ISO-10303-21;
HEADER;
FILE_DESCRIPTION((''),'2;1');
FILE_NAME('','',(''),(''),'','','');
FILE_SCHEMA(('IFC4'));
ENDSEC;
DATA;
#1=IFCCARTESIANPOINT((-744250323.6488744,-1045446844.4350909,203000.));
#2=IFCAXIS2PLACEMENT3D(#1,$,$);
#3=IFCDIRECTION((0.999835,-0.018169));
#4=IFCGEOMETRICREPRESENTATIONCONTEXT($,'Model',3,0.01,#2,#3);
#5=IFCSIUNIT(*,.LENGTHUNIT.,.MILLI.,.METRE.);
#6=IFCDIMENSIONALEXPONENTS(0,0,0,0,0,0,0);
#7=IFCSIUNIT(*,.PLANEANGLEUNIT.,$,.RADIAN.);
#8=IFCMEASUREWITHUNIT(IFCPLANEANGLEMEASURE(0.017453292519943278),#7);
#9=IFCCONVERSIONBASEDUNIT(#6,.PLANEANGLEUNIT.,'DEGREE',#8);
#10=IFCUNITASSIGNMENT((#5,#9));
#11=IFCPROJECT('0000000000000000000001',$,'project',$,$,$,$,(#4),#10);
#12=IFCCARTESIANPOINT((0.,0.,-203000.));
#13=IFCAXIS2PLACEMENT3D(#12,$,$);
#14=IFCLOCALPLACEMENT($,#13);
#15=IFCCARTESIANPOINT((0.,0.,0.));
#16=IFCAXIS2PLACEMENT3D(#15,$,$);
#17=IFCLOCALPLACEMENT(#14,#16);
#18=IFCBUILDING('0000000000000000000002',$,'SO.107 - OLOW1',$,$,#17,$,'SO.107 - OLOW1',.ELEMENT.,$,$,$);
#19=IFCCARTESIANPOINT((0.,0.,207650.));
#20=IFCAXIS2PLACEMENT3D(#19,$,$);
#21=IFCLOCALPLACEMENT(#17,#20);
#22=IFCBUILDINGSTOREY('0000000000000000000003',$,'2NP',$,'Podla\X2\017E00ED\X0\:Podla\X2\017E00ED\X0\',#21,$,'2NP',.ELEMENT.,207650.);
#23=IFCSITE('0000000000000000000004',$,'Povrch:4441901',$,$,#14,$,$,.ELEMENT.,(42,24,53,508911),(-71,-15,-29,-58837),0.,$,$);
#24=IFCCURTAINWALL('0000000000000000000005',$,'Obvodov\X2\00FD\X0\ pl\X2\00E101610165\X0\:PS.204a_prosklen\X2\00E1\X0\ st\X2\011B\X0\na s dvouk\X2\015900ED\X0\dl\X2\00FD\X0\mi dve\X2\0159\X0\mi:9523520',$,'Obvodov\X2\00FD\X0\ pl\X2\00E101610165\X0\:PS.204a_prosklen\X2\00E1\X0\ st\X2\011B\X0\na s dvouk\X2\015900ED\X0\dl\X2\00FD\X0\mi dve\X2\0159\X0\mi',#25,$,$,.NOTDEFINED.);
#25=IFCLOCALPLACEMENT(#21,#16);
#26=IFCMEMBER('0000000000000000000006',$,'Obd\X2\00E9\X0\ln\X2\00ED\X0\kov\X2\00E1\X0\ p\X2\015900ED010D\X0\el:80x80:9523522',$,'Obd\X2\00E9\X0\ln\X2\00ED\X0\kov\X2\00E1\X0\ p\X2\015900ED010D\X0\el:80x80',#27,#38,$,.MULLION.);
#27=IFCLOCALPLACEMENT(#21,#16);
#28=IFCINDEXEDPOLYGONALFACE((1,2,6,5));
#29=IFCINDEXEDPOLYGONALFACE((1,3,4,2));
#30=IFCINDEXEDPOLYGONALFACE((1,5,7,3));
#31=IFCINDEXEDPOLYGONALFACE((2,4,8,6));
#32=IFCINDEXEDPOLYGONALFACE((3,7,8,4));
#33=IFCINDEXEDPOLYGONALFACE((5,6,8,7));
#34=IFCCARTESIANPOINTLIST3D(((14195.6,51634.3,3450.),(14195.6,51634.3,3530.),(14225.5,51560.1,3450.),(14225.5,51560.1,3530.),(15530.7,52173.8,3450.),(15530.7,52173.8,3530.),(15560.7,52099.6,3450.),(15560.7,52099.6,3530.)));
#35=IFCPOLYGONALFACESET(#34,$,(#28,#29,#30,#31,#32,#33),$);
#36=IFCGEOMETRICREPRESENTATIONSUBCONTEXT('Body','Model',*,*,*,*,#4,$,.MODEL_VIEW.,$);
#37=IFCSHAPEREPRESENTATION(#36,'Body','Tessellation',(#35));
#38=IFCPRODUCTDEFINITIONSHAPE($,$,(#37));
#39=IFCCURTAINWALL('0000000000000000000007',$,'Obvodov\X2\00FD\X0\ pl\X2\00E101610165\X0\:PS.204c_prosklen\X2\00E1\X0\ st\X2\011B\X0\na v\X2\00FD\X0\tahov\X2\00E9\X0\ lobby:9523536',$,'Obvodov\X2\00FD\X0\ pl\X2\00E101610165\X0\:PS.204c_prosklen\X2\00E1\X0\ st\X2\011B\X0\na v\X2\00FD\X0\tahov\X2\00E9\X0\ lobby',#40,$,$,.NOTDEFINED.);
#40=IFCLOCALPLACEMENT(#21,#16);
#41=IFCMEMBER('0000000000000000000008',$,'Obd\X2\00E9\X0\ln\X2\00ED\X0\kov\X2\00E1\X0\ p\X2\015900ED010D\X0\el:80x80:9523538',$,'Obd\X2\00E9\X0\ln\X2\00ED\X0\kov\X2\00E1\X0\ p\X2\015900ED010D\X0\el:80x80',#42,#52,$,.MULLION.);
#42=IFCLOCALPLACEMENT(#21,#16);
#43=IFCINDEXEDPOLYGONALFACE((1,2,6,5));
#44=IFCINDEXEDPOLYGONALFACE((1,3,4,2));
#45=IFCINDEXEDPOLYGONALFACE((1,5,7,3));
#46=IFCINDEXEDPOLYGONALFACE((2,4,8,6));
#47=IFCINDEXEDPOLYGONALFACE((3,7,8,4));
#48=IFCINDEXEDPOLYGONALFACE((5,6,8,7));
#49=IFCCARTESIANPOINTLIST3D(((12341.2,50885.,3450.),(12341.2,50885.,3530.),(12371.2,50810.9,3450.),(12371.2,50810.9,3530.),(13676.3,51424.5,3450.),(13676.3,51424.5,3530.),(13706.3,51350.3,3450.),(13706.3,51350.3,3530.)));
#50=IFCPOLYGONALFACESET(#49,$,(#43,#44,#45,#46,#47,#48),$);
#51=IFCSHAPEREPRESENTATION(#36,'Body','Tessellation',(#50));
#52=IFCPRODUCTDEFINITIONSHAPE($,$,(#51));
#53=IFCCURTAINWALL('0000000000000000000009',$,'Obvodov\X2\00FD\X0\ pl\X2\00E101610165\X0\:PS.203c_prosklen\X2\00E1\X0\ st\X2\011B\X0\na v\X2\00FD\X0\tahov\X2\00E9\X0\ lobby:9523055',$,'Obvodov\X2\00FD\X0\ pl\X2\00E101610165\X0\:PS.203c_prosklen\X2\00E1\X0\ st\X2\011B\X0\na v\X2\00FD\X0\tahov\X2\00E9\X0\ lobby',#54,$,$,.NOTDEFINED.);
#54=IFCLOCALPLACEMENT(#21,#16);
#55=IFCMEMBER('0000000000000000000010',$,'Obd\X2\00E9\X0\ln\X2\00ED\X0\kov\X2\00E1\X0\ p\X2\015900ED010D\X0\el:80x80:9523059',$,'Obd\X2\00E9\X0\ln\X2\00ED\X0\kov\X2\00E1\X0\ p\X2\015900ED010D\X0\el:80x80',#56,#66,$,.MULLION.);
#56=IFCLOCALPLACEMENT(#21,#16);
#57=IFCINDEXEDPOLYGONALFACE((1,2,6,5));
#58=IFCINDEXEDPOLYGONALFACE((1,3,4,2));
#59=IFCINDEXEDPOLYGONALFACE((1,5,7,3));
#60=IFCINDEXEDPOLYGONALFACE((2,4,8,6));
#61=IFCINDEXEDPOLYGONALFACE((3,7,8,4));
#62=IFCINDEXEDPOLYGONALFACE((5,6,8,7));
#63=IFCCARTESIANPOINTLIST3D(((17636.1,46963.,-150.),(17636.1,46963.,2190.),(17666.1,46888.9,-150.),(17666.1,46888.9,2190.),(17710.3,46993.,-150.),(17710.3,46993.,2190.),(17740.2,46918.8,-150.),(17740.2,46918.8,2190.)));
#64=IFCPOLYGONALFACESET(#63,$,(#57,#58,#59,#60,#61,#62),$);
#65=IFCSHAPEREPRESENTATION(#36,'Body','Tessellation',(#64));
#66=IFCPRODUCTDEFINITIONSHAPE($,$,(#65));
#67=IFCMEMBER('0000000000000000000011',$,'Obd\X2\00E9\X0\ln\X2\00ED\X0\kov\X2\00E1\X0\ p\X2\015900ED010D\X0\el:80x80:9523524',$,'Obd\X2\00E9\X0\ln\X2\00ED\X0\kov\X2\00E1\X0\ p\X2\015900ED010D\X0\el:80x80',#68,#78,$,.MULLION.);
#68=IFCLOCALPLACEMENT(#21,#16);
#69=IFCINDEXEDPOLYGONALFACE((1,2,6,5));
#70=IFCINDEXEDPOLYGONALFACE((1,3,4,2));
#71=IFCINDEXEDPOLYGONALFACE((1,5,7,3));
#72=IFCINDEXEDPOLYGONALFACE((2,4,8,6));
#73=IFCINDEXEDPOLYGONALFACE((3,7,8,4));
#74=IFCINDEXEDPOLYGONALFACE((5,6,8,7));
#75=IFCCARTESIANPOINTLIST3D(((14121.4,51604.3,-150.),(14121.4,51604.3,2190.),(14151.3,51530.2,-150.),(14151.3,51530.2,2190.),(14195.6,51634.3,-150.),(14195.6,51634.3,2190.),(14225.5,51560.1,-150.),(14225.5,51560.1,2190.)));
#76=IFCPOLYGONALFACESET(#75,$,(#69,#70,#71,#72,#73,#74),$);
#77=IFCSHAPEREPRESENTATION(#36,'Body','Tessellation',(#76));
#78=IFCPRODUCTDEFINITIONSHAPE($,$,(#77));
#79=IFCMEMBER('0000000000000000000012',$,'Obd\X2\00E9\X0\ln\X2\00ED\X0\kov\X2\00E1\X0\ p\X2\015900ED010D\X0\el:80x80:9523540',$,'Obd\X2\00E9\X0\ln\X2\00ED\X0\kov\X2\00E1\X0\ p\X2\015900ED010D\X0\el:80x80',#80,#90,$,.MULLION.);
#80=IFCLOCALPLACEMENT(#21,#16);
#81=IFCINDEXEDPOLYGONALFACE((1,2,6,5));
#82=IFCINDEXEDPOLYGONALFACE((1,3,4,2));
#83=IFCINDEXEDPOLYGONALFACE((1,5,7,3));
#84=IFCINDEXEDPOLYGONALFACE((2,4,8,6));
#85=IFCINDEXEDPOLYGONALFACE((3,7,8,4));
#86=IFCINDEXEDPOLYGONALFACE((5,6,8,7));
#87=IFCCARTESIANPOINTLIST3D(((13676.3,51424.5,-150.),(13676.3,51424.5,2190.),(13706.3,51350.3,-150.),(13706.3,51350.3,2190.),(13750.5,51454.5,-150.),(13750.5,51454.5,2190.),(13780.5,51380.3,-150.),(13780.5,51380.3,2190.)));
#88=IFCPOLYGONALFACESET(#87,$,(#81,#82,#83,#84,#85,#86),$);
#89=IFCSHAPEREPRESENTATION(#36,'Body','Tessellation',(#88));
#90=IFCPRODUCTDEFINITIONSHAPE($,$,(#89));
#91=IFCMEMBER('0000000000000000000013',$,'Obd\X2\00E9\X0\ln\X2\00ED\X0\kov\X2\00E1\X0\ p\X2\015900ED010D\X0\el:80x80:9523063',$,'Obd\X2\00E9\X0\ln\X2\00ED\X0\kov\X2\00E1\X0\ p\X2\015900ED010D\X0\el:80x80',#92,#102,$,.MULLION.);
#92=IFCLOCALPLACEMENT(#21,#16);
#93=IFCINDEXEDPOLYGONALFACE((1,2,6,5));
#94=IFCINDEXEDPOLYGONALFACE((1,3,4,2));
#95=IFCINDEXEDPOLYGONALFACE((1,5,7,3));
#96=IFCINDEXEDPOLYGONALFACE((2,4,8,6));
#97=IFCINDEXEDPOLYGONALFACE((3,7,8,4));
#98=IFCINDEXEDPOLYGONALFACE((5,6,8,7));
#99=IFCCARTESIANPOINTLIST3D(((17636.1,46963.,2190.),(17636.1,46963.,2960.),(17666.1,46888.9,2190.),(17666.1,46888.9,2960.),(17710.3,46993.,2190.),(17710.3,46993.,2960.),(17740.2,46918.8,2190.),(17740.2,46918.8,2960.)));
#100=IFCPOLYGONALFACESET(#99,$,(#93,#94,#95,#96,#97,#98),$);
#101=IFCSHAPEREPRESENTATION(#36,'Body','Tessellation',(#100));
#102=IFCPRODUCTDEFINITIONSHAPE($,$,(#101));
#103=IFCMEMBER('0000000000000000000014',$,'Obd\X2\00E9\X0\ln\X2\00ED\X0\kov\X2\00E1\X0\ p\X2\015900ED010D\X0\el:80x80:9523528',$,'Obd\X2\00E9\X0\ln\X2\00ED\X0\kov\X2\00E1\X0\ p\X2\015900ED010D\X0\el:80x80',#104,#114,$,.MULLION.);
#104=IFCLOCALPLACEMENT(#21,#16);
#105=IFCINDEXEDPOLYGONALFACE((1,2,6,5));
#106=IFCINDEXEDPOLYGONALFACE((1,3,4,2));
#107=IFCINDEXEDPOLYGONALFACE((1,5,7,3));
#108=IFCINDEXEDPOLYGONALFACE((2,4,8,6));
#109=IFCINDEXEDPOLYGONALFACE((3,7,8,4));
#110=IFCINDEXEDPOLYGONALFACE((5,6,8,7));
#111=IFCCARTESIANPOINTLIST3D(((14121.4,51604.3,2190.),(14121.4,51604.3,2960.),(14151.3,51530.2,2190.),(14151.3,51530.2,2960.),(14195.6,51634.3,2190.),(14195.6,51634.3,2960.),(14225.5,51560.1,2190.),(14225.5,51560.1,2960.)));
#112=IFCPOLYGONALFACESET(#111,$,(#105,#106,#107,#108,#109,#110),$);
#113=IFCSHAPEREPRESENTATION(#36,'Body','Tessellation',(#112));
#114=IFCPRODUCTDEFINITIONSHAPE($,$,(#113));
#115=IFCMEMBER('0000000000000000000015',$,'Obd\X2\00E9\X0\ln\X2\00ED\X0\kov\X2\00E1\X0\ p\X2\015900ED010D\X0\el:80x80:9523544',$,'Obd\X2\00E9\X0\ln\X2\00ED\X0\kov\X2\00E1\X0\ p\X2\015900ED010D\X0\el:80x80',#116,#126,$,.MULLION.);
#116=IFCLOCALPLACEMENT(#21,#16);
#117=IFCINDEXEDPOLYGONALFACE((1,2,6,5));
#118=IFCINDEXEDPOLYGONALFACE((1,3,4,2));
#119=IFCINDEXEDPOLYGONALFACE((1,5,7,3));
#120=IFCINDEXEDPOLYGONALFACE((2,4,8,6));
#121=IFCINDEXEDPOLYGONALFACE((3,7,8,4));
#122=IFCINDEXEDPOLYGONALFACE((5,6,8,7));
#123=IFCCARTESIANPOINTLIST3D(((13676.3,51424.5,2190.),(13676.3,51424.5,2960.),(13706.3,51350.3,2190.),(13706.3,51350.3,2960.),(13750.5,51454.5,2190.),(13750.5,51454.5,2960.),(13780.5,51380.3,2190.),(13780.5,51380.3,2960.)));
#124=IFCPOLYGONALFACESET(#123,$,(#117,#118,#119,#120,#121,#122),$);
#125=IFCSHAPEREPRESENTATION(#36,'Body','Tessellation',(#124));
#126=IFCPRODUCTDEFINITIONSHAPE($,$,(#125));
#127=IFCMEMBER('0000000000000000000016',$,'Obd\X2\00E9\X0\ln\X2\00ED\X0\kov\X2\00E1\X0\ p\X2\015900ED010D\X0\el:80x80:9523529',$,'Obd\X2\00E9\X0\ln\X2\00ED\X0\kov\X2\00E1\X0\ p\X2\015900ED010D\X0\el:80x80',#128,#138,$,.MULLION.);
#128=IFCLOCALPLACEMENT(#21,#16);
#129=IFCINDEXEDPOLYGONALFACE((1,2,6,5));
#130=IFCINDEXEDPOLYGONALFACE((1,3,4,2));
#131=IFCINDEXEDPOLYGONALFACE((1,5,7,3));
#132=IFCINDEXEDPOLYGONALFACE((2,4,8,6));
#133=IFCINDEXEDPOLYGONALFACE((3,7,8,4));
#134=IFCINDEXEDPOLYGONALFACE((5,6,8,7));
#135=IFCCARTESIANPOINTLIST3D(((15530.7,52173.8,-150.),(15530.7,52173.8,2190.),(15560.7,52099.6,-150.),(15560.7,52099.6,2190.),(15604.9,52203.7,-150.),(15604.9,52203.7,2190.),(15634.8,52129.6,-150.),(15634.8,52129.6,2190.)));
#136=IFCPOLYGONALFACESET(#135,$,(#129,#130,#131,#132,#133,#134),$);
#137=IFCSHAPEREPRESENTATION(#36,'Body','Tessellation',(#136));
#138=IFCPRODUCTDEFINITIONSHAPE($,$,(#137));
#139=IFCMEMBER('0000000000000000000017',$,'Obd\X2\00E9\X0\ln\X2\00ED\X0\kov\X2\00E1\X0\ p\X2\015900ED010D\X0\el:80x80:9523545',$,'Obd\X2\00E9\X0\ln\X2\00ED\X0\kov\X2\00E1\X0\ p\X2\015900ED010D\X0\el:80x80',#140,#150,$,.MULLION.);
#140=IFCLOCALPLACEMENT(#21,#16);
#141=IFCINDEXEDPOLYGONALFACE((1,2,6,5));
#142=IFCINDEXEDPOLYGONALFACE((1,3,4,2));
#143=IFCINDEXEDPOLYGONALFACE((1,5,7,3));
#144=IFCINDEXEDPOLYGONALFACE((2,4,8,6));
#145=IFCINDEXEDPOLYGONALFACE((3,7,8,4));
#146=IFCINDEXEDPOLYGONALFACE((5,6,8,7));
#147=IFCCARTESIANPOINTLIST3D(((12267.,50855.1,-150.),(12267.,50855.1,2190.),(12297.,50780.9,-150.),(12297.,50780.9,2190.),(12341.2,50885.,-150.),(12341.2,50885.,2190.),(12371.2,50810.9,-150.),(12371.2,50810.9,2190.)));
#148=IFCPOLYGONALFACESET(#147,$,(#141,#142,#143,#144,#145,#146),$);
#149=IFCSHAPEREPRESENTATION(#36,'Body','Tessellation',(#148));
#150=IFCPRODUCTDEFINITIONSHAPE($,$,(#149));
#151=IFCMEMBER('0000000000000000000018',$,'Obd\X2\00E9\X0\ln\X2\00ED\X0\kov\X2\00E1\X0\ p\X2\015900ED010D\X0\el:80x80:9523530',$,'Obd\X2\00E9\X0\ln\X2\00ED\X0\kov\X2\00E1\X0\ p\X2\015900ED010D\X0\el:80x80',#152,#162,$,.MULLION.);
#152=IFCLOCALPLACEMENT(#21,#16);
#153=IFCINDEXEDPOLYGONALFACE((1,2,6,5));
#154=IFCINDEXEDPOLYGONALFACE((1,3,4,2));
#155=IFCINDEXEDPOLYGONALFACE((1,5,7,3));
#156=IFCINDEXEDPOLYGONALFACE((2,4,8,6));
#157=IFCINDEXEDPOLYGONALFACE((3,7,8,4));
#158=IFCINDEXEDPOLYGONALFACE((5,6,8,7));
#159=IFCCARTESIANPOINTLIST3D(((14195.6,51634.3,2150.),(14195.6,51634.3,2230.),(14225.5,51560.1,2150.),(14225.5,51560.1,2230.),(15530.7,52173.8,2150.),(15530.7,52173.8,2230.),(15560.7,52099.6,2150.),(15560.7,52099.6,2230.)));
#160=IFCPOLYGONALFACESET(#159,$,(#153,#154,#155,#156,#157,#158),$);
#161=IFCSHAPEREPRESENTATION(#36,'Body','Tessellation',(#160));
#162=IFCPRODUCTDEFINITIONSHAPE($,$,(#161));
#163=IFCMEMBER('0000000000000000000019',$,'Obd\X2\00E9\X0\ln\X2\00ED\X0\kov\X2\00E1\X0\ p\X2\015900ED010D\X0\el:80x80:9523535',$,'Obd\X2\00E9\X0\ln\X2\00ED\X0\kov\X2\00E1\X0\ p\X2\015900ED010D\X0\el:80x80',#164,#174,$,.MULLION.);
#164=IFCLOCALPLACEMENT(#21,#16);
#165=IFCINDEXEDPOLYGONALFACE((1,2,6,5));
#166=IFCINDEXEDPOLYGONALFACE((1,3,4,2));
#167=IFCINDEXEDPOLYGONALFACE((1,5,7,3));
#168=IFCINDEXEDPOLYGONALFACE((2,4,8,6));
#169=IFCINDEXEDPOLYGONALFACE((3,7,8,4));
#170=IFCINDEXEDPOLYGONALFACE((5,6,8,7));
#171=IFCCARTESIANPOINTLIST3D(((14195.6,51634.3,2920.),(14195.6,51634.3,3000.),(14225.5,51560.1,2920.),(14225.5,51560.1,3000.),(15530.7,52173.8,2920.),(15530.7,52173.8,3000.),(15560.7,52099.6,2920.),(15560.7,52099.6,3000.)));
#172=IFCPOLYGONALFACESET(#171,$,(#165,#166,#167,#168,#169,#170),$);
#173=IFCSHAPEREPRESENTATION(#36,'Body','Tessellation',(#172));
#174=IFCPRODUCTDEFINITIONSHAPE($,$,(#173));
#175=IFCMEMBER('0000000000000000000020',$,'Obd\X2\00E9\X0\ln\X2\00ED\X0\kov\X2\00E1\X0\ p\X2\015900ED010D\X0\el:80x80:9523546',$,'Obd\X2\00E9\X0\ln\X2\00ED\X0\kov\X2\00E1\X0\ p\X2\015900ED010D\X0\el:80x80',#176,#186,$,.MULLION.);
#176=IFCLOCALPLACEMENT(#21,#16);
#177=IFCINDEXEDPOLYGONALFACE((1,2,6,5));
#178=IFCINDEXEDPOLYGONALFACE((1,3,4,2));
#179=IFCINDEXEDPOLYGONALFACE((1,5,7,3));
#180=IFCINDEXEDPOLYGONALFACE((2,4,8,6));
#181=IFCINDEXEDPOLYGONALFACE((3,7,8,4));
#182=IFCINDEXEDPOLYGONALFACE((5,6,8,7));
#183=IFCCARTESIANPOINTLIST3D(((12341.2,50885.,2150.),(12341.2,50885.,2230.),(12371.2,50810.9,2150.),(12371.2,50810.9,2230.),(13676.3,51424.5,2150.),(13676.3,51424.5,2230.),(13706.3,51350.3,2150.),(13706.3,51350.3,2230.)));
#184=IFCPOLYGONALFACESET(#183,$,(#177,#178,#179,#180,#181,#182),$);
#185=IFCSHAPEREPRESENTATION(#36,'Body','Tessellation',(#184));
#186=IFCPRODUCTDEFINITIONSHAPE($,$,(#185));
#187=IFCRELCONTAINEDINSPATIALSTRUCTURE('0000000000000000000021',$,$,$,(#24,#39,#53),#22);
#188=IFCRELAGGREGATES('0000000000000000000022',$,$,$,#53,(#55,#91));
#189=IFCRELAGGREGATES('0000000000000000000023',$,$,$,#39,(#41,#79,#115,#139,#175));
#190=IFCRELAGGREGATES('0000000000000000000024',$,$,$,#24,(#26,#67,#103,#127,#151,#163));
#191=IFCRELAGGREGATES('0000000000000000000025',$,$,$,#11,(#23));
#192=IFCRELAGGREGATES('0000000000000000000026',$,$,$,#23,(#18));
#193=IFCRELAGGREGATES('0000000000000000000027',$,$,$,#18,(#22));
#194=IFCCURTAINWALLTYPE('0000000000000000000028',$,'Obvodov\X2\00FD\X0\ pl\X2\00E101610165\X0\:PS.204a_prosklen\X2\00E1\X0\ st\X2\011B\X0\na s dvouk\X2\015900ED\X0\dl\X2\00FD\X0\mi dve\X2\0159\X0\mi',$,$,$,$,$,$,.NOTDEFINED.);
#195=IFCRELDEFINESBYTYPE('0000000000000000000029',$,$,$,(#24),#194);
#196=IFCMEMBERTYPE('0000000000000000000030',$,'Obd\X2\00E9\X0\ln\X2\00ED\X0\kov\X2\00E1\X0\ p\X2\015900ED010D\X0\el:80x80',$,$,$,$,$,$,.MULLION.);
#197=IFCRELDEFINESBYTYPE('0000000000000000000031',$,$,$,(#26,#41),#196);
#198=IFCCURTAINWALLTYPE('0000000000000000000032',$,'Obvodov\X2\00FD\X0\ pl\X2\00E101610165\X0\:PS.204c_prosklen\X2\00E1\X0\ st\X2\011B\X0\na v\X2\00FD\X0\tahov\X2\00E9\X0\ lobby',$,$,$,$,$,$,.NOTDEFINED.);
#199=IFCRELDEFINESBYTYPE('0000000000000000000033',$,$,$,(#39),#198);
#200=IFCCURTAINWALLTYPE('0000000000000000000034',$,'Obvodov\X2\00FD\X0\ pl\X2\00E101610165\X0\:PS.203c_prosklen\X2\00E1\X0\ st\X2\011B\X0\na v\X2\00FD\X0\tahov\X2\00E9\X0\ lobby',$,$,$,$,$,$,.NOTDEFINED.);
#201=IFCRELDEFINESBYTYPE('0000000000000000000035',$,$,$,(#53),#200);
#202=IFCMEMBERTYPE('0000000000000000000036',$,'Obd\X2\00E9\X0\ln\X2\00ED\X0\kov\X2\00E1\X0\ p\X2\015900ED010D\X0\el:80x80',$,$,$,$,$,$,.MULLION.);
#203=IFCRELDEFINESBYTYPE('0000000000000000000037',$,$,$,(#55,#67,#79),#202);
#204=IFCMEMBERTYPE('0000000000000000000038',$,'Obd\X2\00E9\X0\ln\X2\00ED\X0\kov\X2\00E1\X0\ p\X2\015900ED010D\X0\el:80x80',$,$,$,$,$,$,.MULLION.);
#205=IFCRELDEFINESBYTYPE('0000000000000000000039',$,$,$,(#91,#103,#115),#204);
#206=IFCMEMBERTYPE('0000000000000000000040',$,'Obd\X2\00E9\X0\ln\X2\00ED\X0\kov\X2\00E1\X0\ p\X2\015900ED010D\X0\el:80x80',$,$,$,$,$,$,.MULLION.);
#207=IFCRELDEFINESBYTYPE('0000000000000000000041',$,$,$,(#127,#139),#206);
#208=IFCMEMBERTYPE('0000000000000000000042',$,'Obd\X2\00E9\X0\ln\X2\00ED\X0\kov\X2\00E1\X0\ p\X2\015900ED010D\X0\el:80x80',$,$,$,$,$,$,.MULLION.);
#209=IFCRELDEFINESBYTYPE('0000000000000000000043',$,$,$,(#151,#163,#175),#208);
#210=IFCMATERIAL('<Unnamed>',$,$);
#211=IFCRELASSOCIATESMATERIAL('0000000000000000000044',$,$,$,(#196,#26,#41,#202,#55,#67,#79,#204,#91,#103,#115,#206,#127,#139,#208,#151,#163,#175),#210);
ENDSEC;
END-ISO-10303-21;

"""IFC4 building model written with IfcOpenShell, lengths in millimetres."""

from ifc_helpers import new_model, entity, si_unit, converted_unit, direction, frame, origin, place, context, subcontext, project, spatial, indexed_curve, outline, extrude, source, transform, mapped, material, type_object, type_shapes, element, aggregate, save


model = new_model("IFC4")

# Units and contexts
model_context = context("Model", 3, precision=0.01, world=frame((-744250323.6488744, -1045446844.4350909, 203000.0)), true_north=direction((0.999835, -0.018169)))
body_context = subcontext(model_context, "Body", "Model", "MODEL_VIEW")
ifc_project = project(units=[si_unit("LENGTHUNIT", "METRE", prefix="MILLI"), converted_unit("PLANEANGLEUNIT", "DEGREE", entity("IfcPlaneAngleMeasure", 0.017453292519943278), si_unit("PLANEANGLEUNIT", "RADIAN"), dimensions=[0, 0, 0, 0, 0, 0, 0])], contexts=[model_context])

# Site, building, storey
site_placement = place(None, frame((0.0, 0.0, -203000.0)))
site = spatial("IfcSite", under=ifc_project, at=site_placement, Name="Povrch:4441901", CompositionType="ELEMENT", RefLatitude=(42, 24, 53, 508911), RefLongitude=(-71, -15, -29, -58837), RefElevation=0.0)
building_placement = place(site_placement, origin())
building = spatial("IfcBuilding", under=site, at=building_placement, Name="SO.107 - OLOW1", LongName="SO.107 - OLOW1", CompositionType="ELEMENT")
storey_placement = place(building_placement, frame((0.0, 0.0, 207650.0)))
storey = spatial("IfcBuildingStorey", under=building, at=storey_placement, Name="2NP", ObjectType="Podlaží:Podlaží", LongName="2NP", CompositionType="ELEMENT", Elevation=207650.0)

# Curtain walls, members
curtain_wall_type_1 = type_object("IfcCurtainWallType", Name="Obvodový plášť:PS.204a_prosklená stěna s dvoukřídlými dveřmi", PredefinedType="NOTDEFINED")
curtain_wall_1_placement = place(storey_placement, frame((0.0, 0.0, -207650.0)))
curtain_wall_1 = element("IfcCurtainWall", 1, at=curtain_wall_1_placement, inside=storey, type_object=curtain_wall_type_1, Name="Obvodový plášť:PS.204a_prosklená stěna s dvoukřídlými dveřmi:9523520", ObjectType="Obvodový plášť:PS.204a_prosklená stěna s dvoukřídlými dveřmi", PredefinedType="NOTDEFINED")
ifc_material_1 = material(Name="<Unnamed>")
member_type_1 = type_object("IfcMemberType", Name="Obdélníková příčel:80x80", PredefinedType="MULLION", material=ifc_material_1)
shared_shape_1 = source(origin(), body_context, "Body", "SweptSolid", [
    extrude(outline(indexed_curve([(-40.0, -40.0), (40.0, -40.0), (40.0, 40.0), (-40.0, 40.0), (-40.0, -40.0)], self_intersect=False)), frame((-40.0, 0.0, -1440.0), z_axis=(0.0, 0.0, 1.0), x_axis=(-1.0, 0.0, 0.0)), (0.0, 0.0, 1.0), 1440.0),
])
type_shapes(member_type_1, [shared_shape_1])
member_1_placement = place(curtain_wall_1_placement, frame((14210.5, 51597.2, 211180.0), z_axis=(-0.927176, -0.374626, 0.0), x_axis=(0.0, 0.0, 1.0)))
member_1 = element("IfcMember", 2, at=member_1_placement, type_object=member_type_1, material=ifc_material_1, Name="Obdélníková příčel:80x80:9523522", ObjectType="Obdélníková příčel:80x80", PredefinedType="MULLION", context=body_context, shape_type="MappedRepresentation", body=[
    mapped(shared_shape_1, transform((0.0, 0.0, 0.0), scale=1.0)),
])
curtain_wall_type_2 = type_object("IfcCurtainWallType", Name="Obvodový plášť:PS.204c_prosklená stěna výtahové lobby", PredefinedType="NOTDEFINED")
curtain_wall_2_placement = place(storey_placement, frame((0.0, 0.0, -207650.0)))
curtain_wall_2 = element("IfcCurtainWall", 3, at=curtain_wall_2_placement, inside=storey, type_object=curtain_wall_type_2, Name="Obvodový plášť:PS.204c_prosklená stěna výtahové lobby:9523536", ObjectType="Obvodový plášť:PS.204c_prosklená stěna výtahové lobby", PredefinedType="NOTDEFINED")
member_2_placement = place(curtain_wall_2_placement, frame((13691.3, 51387.4, 211180.0), z_axis=(0.927176, 0.374626, 0.0), x_axis=(0.0, 0.0, 1.0)))
member_2 = element("IfcMember", 4, at=member_2_placement, type_object=member_type_1, material=ifc_material_1, Name="Obdélníková příčel:80x80:9523538", ObjectType="Obdélníková příčel:80x80", PredefinedType="MULLION", context=body_context, shape_type="MappedRepresentation", body=[
    mapped(shared_shape_1, transform((0.0, 0.0, 0.0), scale=1.0)),
])
curtain_wall_type_3 = type_object("IfcCurtainWallType", Name="Obvodový plášť:PS.203c_prosklená stěna výtahové lobby", PredefinedType="NOTDEFINED")
curtain_wall_3_placement = place(storey_placement, frame((0.0, 0.0, -207650.0)))
curtain_wall_3 = element("IfcCurtainWall", 5, at=curtain_wall_3_placement, inside=storey, type_object=curtain_wall_type_3, Name="Obvodový plášť:PS.203c_prosklená stěna výtahové lobby:9523055", ObjectType="Obvodový plášť:PS.203c_prosklená stěna výtahové lobby", PredefinedType="NOTDEFINED")
member_type_2 = type_object("IfcMemberType", Name="Obdélníková příčel:80x80", PredefinedType="MULLION", material=ifc_material_1)
shared_shape_2 = source(origin(), body_context, "Body", "SweptSolid", [
    extrude(outline(indexed_curve([(-40.0, -40.0), (40.0, -40.0), (40.0, 40.0), (-40.0, 40.0), (-40.0, -40.0)], self_intersect=False)), frame((-40.0, 0.0, -2340.0), z_axis=(0.0, 0.0, 1.0), x_axis=(-1.0, 0.0, 0.0)), (0.0, 0.0, 1.0), 2340.0),
])
type_shapes(member_type_2, [shared_shape_2])
member_3_placement = place(curtain_wall_3_placement, frame((17725.2, 46955.9, 207500.0), z_axis=(0.0, 0.0, -1.0), x_axis=(0.927176, 0.374626, 0.0)))
member_3 = element("IfcMember", 6, at=member_3_placement, type_object=member_type_2, material=ifc_material_1, Name="Obdélníková příčel:80x80:9523059", ObjectType="Obdélníková příčel:80x80", PredefinedType="MULLION", context=body_context, shape_type="MappedRepresentation", body=[
    mapped(shared_shape_2, transform((0.0, 0.0, 0.0), scale=1.0)),
])

# Members
member_4_placement = place(curtain_wall_1_placement, frame((14136.4, 51567.2, 207500.0), z_axis=(0.0, 0.0, -1.0), x_axis=(-0.927176, -0.374626, 0.0)))
member_4 = element("IfcMember", 7, at=member_4_placement, type_object=member_type_2, material=ifc_material_1, Name="Obdélníková příčel:80x80:9523524", ObjectType="Obdélníková příčel:80x80", PredefinedType="MULLION", context=body_context, shape_type="MappedRepresentation", body=[
    mapped(shared_shape_2, transform((0.0, 0.0, 0.0), scale=1.0)),
])
member_5_placement = place(curtain_wall_2_placement, frame((13765.5, 51417.4, 207500.0), z_axis=(0.0, 0.0, -1.0), x_axis=(0.927176, 0.374626, 0.0)))
member_5 = element("IfcMember", 8, at=member_5_placement, type_object=member_type_2, material=ifc_material_1, Name="Obdélníková příčel:80x80:9523540", ObjectType="Obdélníková příčel:80x80", PredefinedType="MULLION", context=body_context, shape_type="MappedRepresentation", body=[
    mapped(shared_shape_2, transform((0.0, 0.0, 0.0), scale=1.0)),
])
member_type_3 = type_object("IfcMemberType", Name="Obdélníková příčel:80x80", PredefinedType="MULLION", material=ifc_material_1)
shared_shape_3 = source(origin(), body_context, "Body", "SweptSolid", [
    extrude(outline(indexed_curve([(-40.0, -40.0), (40.0, -40.0), (40.0, 40.0), (-40.0, 40.0), (-40.0, -40.0)], self_intersect=False)), frame((-40.0, 0.0, -770.0), z_axis=(0.0, 0.0, 1.0), x_axis=(-1.0, 0.0, 0.0)), (0.0, 0.0, 1.0), 770.0),
])
type_shapes(member_type_3, [shared_shape_3])
member_6_placement = place(curtain_wall_3_placement, frame((17725.2, 46955.9, 209840.0), z_axis=(0.0, 0.0, -1.0), x_axis=(0.927176, 0.374626, 0.0)))
member_6 = element("IfcMember", 9, at=member_6_placement, type_object=member_type_3, material=ifc_material_1, Name="Obdélníková příčel:80x80:9523063", ObjectType="Obdélníková příčel:80x80", PredefinedType="MULLION", context=body_context, shape_type="MappedRepresentation", body=[
    mapped(shared_shape_3, transform((0.0, 0.0, 0.0), scale=1.0)),
])
member_7_placement = place(curtain_wall_1_placement, frame((14136.4, 51567.2, 209840.0), z_axis=(0.0, 0.0, -1.0), x_axis=(-0.927176, -0.374626, 0.0)))
member_7 = element("IfcMember", 10, at=member_7_placement, type_object=member_type_3, material=ifc_material_1, Name="Obdélníková příčel:80x80:9523528", ObjectType="Obdélníková příčel:80x80", PredefinedType="MULLION", context=body_context, shape_type="MappedRepresentation", body=[
    mapped(shared_shape_3, transform((0.0, 0.0, 0.0), scale=1.0)),
])
member_8_placement = place(curtain_wall_2_placement, frame((13765.5, 51417.4, 209840.0), z_axis=(0.0, 0.0, -1.0), x_axis=(0.927176, 0.374626, 0.0)))
member_8 = element("IfcMember", 11, at=member_8_placement, type_object=member_type_3, material=ifc_material_1, Name="Obdélníková příčel:80x80:9523544", ObjectType="Obdélníková příčel:80x80", PredefinedType="MULLION", context=body_context, shape_type="MappedRepresentation", body=[
    mapped(shared_shape_3, transform((0.0, 0.0, 0.0), scale=1.0)),
])
member_type_4 = type_object("IfcMemberType", Name="Obdélníková příčel:80x80", PredefinedType="MULLION", material=ifc_material_1)
shared_shape_4 = source(origin(), body_context, "Body", "SweptSolid", [
    extrude(outline(indexed_curve([(-40.0, -40.0), (40.0, -40.0), (40.0, 40.0), (-40.0, 40.0), (-40.0, -40.0)], self_intersect=False)), frame((-40.0, 0.0, -2340.0), z_axis=(0.0, 0.0, 1.0), x_axis=(-1.0, 0.0, 0.0)), (0.0, 0.0, 1.0), 2340.0),
])
type_shapes(member_type_4, [shared_shape_4])
member_9_placement = place(curtain_wall_1_placement, frame((15619.8, 52166.6, 209840.0), z_axis=(0.0, 0.0, 1.0), x_axis=(0.927176, 0.374626, 0.0)))
member_9 = element("IfcMember", 12, at=member_9_placement, type_object=member_type_4, material=ifc_material_1, Name="Obdélníková příčel:80x80:9523529", ObjectType="Obdélníková příčel:80x80", PredefinedType="MULLION", context=body_context, shape_type="MappedRepresentation", body=[
    mapped(shared_shape_4, transform((0.0, 0.0, 0.0), scale=1.0)),
])
member_10_placement = place(curtain_wall_2_placement, frame((12282.0, 50818.0, 209840.0), z_axis=(0.0, 0.0, 1.0), x_axis=(-0.927176, -0.374626, 0.0)))
member_10 = element("IfcMember", 13, at=member_10_placement, type_object=member_type_4, material=ifc_material_1, Name="Obdélníková příčel:80x80:9523545", ObjectType="Obdélníková příčel:80x80", PredefinedType="MULLION", context=body_context, shape_type="MappedRepresentation", body=[
    mapped(shared_shape_4, transform((0.0, 0.0, 0.0), scale=1.0)),
])
member_type_5 = type_object("IfcMemberType", Name="Obdélníková příčel:80x80", PredefinedType="MULLION", material=ifc_material_1)
shared_shape_5 = source(origin(), body_context, "Body", "SweptSolid", [
    extrude(outline(indexed_curve([(-40.0, -40.0), (40.0, -40.0), (40.0, 40.0), (-40.0, 40.0), (-40.0, -40.0)], self_intersect=False)), frame((0.0, 0.0, -1440.0), z_axis=(0.0, 0.0, 1.0), x_axis=(-1.0, 0.0, 0.0)), (0.0, 0.0, 1.0), 1440.0),
])
type_shapes(member_type_5, [shared_shape_5])
member_11_placement = place(curtain_wall_1_placement, frame((14210.5, 51597.2, 209840.0), z_axis=(-0.927176, -0.374626, 0.0), x_axis=(0.0, 0.0, 1.0)))
member_11 = element("IfcMember", 14, at=member_11_placement, type_object=member_type_5, material=ifc_material_1, Name="Obdélníková příčel:80x80:9523530", ObjectType="Obdélníková příčel:80x80", PredefinedType="MULLION", context=body_context, shape_type="MappedRepresentation", body=[
    mapped(shared_shape_5, transform((0.0, 0.0, 0.0), scale=1.0)),
])
member_12_placement = place(curtain_wall_1_placement, frame((14210.5, 51597.2, 210610.0), z_axis=(-0.927176, -0.374626, 0.0), x_axis=(0.0, 0.0, 1.0)))
member_12 = element("IfcMember", 15, at=member_12_placement, type_object=member_type_5, material=ifc_material_1, Name="Obdélníková příčel:80x80:9523535", ObjectType="Obdélníková příčel:80x80", PredefinedType="MULLION", context=body_context, shape_type="MappedRepresentation", body=[
    mapped(shared_shape_5, transform((0.0, 0.0, 0.0), scale=1.0)),
])
member_13_placement = place(curtain_wall_2_placement, frame((13691.3, 51387.4, 209840.0), z_axis=(0.927176, 0.374626, 0.0), x_axis=(0.0, 0.0, 1.0)))
member_13 = element("IfcMember", 16, at=member_13_placement, type_object=member_type_5, material=ifc_material_1, Name="Obdélníková příčel:80x80:9523546", ObjectType="Obdélníková příčel:80x80", PredefinedType="MULLION", context=body_context, shape_type="MappedRepresentation", body=[
    mapped(shared_shape_5, transform((0.0, 0.0, 0.0), scale=1.0)),
])
aggregate(curtain_wall_3, [member_3, member_6])

aggregate(curtain_wall_2, [member_2, member_5, member_8, member_10, member_13])

aggregate(curtain_wall_1, [member_1, member_4, member_7, member_9, member_11, member_12])

save(model, "model.ifc")
